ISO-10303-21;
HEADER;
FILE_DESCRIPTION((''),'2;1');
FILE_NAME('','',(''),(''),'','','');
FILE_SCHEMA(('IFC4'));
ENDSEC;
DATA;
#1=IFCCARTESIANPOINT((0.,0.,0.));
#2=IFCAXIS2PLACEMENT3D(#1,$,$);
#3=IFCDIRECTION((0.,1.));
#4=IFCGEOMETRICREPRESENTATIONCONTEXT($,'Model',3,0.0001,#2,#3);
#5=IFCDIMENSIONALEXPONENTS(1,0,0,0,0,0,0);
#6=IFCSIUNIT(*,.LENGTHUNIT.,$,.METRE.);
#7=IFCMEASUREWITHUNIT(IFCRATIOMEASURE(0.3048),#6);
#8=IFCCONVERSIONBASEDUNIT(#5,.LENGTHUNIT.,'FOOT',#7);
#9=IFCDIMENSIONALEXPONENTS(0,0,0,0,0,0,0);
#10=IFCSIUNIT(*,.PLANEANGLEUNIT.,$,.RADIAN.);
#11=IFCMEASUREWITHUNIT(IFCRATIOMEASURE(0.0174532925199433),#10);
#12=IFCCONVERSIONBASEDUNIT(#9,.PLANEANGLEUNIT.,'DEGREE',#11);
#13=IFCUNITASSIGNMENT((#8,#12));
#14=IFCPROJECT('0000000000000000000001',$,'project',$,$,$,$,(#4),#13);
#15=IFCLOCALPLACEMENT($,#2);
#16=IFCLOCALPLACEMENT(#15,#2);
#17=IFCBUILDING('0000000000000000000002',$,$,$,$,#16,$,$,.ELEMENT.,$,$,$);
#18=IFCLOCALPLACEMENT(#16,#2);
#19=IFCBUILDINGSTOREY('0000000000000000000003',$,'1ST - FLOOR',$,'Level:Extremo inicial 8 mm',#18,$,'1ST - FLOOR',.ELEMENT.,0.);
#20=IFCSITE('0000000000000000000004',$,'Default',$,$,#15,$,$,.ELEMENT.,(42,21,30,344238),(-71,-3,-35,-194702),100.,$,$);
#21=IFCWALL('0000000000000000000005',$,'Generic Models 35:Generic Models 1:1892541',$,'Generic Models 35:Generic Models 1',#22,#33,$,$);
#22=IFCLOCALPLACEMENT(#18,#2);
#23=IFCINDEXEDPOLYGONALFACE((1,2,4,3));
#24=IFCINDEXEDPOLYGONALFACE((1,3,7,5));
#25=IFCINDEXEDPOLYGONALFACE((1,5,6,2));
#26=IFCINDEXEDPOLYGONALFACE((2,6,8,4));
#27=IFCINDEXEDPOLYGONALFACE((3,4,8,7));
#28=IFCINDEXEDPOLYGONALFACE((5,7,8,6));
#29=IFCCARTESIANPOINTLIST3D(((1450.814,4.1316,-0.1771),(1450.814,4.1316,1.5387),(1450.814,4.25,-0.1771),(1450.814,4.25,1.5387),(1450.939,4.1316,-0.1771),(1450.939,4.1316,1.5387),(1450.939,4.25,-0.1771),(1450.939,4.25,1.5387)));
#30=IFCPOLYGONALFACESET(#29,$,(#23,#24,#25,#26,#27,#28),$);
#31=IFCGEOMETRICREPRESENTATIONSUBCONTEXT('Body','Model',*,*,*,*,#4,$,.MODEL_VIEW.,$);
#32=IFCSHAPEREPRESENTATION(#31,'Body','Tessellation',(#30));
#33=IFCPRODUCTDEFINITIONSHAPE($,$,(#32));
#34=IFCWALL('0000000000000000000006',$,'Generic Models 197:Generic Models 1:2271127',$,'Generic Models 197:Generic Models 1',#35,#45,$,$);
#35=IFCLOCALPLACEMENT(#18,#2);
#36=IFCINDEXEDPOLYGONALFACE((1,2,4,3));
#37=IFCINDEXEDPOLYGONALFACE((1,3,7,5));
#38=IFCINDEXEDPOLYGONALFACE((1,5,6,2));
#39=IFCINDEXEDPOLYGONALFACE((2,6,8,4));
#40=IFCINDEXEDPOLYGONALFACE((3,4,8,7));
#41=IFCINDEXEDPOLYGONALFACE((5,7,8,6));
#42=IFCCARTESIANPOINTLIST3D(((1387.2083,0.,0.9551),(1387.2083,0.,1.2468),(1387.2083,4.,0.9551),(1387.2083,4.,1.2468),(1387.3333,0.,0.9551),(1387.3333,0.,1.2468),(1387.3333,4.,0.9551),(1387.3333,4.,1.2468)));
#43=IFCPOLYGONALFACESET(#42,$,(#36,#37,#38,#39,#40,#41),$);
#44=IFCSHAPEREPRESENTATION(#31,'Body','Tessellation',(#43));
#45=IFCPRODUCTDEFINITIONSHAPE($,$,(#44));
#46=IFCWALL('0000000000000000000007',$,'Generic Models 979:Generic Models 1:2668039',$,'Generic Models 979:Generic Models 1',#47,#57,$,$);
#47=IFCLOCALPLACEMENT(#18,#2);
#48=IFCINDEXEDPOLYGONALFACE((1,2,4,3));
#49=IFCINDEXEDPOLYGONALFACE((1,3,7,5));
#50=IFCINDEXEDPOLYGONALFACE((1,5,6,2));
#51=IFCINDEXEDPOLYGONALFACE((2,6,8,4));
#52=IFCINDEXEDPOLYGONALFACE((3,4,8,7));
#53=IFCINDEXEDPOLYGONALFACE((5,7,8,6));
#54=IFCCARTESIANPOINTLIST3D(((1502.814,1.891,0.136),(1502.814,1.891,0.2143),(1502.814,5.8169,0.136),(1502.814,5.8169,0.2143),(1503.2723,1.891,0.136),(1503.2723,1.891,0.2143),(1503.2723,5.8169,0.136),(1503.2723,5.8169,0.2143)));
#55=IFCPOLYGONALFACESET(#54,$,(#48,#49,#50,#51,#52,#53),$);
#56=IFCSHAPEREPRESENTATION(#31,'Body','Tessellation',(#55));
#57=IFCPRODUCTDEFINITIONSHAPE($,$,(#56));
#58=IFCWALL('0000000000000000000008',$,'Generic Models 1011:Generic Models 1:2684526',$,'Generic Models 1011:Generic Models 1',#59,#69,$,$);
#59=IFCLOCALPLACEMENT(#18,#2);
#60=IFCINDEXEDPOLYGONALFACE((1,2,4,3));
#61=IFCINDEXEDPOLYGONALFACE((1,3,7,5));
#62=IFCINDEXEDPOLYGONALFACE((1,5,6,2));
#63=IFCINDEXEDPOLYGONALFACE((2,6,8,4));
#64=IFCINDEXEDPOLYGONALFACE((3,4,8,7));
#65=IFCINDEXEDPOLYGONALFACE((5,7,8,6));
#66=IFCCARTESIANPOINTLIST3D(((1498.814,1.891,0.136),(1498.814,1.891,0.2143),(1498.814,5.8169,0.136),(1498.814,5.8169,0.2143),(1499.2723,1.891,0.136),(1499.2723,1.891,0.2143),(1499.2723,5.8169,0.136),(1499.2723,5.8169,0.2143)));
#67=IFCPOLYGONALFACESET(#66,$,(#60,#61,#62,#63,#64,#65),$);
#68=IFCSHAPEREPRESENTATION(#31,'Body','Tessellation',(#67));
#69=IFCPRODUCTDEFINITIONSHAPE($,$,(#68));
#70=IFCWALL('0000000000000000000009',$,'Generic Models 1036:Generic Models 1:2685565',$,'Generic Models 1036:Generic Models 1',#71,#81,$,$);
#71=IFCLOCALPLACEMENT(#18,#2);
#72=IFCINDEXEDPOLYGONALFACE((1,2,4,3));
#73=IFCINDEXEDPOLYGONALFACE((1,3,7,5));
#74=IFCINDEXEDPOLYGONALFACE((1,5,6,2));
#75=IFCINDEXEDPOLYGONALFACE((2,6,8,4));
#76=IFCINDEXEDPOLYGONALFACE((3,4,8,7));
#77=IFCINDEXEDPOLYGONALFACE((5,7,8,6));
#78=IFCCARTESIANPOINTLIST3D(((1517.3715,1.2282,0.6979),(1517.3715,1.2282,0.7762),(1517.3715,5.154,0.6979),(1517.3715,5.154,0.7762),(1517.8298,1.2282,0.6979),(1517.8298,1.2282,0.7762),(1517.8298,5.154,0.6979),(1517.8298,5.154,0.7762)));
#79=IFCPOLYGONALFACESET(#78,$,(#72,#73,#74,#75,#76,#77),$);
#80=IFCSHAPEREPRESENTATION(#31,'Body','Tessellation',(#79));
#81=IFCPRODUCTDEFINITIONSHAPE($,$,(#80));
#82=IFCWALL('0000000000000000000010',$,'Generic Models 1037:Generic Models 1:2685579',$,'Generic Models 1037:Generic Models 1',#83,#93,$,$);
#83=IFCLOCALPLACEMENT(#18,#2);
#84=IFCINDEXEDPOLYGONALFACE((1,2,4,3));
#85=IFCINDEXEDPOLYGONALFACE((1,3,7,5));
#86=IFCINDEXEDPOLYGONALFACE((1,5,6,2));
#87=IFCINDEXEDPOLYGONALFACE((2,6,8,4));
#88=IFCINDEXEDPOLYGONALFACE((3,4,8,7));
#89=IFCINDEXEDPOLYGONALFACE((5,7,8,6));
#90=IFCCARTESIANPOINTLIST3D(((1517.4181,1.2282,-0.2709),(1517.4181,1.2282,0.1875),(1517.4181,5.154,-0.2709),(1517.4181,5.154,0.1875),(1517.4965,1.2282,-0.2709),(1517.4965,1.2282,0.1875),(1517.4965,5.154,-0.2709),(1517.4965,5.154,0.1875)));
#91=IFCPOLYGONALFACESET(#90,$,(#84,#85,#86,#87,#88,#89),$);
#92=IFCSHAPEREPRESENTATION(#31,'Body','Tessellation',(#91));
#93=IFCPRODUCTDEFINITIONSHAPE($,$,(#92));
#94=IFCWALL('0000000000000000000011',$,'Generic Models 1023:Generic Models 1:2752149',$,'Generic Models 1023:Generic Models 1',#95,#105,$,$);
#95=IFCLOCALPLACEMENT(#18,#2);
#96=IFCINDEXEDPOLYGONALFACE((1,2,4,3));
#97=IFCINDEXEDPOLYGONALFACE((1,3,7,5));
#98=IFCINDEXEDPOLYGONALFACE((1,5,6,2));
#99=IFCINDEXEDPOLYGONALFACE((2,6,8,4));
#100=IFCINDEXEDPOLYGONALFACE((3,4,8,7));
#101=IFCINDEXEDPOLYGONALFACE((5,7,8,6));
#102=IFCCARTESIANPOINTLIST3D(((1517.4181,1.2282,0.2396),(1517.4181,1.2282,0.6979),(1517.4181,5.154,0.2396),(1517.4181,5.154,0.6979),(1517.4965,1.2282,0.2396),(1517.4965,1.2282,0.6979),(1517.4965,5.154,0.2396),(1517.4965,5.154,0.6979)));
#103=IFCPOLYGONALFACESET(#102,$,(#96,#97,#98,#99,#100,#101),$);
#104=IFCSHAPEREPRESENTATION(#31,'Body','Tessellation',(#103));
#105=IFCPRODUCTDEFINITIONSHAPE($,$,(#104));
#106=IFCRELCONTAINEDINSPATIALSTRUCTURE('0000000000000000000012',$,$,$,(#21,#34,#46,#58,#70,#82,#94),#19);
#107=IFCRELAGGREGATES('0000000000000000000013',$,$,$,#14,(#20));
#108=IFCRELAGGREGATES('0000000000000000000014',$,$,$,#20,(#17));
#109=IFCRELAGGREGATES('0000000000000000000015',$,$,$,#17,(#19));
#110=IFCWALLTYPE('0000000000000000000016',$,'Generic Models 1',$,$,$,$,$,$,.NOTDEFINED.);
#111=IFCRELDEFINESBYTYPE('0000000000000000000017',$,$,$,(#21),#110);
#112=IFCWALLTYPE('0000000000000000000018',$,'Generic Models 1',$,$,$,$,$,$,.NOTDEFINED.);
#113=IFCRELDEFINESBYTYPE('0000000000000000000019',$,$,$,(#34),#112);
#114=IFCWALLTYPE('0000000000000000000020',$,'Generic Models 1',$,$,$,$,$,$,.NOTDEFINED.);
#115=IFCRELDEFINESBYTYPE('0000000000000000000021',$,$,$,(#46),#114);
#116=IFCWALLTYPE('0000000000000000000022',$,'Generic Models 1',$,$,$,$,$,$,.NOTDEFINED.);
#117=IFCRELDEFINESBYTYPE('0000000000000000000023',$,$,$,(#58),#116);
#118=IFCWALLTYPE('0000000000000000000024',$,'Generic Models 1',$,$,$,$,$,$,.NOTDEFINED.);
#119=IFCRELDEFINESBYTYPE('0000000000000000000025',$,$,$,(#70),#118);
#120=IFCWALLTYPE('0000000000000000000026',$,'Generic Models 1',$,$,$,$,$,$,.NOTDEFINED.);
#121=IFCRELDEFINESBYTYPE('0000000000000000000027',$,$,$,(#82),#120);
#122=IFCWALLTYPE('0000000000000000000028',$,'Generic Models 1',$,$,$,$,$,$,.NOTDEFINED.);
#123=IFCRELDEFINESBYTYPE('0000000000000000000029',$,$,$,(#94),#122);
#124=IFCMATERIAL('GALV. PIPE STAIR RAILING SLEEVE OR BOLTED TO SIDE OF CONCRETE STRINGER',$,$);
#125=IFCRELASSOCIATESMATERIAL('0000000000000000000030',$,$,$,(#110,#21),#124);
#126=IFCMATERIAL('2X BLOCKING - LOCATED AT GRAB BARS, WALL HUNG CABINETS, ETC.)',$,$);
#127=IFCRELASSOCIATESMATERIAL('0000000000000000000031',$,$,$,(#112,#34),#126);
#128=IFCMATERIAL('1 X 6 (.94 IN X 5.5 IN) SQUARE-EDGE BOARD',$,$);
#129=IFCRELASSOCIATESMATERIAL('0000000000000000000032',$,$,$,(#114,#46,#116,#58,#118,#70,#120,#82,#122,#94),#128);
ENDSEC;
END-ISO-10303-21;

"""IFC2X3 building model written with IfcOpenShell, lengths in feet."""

from ifc_helpers import new_model, entity, si_unit, converted_unit, direction, frame, frame_2d, origin, place, context, subcontext, project, spatial, rectangle, extrude, material, type_object, element, save


model = new_model("IFC2X3")

# Units and contexts
model_context = context("Model", 3, precision=0.0001, world=origin(), true_north=direction((0.0, 1.0)))
body_context = subcontext(model_context, "Body", "Model", "MODEL_VIEW")
ifc_project = project(units=[converted_unit("LENGTHUNIT", "FOOT", entity("IfcRatioMeasure", 0.3048), si_unit("LENGTHUNIT", "METRE"), dimensions=[1, 0, 0, 0, 0, 0, 0]), converted_unit("PLANEANGLEUNIT", "DEGREE", entity("IfcRatioMeasure", 0.0174532925199433), si_unit("PLANEANGLEUNIT", "RADIAN"), dimensions=[0, 0, 0, 0, 0, 0, 0])], contexts=[model_context])

# Site, building, storey
site_placement = place(None, origin())
site = spatial("IfcSite", under=ifc_project, at=site_placement, Name="Default", CompositionType="ELEMENT", RefLatitude=(42, 21, 30, 344238), RefLongitude=(-71, -3, -35, -194702), RefElevation=100.0)
building_placement = place(site_placement, origin())
building = spatial("IfcBuilding", under=site, at=building_placement, CompositionType="ELEMENT")
storey_placement = place(building_placement, origin())
storey = spatial("IfcBuildingStorey", under=building, at=storey_placement, Name="1ST - FLOOR", ObjectType="Level:Extremo inicial 8 mm", LongName="1ST - FLOOR", CompositionType="ELEMENT", Elevation=0.0)

# Walls
ifc_material_1 = material(Name="GALV. PIPE STAIR RAILING SLEEVE OR BOLTED TO SIDE OF CONCRETE STRINGER")
wall_type_1 = type_object("IfcWallType", Name="Generic Models 1", PredefinedType="NOTDEFINED", material=ifc_material_1)
wall_1_placement = place(storey_placement, frame((1450.814, 4.1316, -0.1771)))
element("IfcWall", 1, at=wall_1_placement, inside=storey, type_object=wall_type_1, material=ifc_material_1, Name="Generic Models 35:Generic Models 1:1892541", ObjectType="Generic Models 35:Generic Models 1", context=body_context, shape_type="SweptSolid", body=[
    extrude(rectangle(XDim=0.1184, YDim=0.125, at=frame_2d((0.0, 0.0), x_axis=(1.0, 0.0))), frame((0.0625, 0.0592, 0.0), z_axis=(0.0, 0.0, 1.0), x_axis=(0.0, 1.0, 0.0)), (0.0, 0.0, 1.0), 1.7158),
])
ifc_material_2 = material(Name="2X BLOCKING - LOCATED AT GRAB BARS, WALL HUNG CABINETS, ETC.)")
wall_type_2 = type_object("IfcWallType", Name="Generic Models 1", PredefinedType="NOTDEFINED", material=ifc_material_2)
wall_2_placement = place(storey_placement, frame((1387.2083, 0.0, 0.9551), z_axis=(0.0, 0.0, 1.0), x_axis=(0.0, 1.0, 0.0)))
element("IfcWall", 2, at=wall_2_placement, inside=storey, type_object=wall_type_2, material=ifc_material_2, Name="Generic Models 197:Generic Models 1:2271127", ObjectType="Generic Models 197:Generic Models 1", context=body_context, shape_type="SweptSolid", body=[
    extrude(rectangle(XDim=4.0, YDim=0.125, at=frame_2d((0.0, 0.0), x_axis=(1.0, 0.0))), frame((2.0, -0.0625, 0.0)), (0.0, 0.0, 1.0), 0.2917),
])
ifc_material_3 = material(Name="1 X 6 (.94 IN X 5.5 IN) SQUARE-EDGE BOARD")
wall_type_3 = type_object("IfcWallType", Name="Generic Models 1", PredefinedType="NOTDEFINED", material=ifc_material_3)
wall_3_placement = place(storey_placement, frame((1502.814, 1.891, 0.136), z_axis=(0.0, 0.0, 1.0), x_axis=(0.0, 1.0, 0.0)))
element("IfcWall", 3, at=wall_3_placement, inside=storey, type_object=wall_type_3, material=ifc_material_3, Name="Generic Models 979:Generic Models 1:2668039", ObjectType="Generic Models 979:Generic Models 1", context=body_context, shape_type="SweptSolid", body=[
    extrude(rectangle(XDim=3.9258, YDim=0.4583, at=frame_2d((0.0, 0.0), x_axis=(1.0, 0.0))), frame((1.9629, -0.2292, 0.0)), (0.0, 0.0, 1.0), 0.0783),
])
wall_type_4 = type_object("IfcWallType", Name="Generic Models 1", PredefinedType="NOTDEFINED", material=ifc_material_3)
wall_4_placement = place(storey_placement, frame((1498.814, 1.891, 0.136), z_axis=(0.0, 0.0, 1.0), x_axis=(0.0, 1.0, 0.0)))
element("IfcWall", 4, at=wall_4_placement, inside=storey, type_object=wall_type_4, material=ifc_material_3, Name="Generic Models 1011:Generic Models 1:2684526", ObjectType="Generic Models 1011:Generic Models 1", context=body_context, shape_type="SweptSolid", body=[
    extrude(rectangle(XDim=3.9258, YDim=0.4583, at=frame_2d((0.0, 0.0), x_axis=(1.0, 0.0))), frame((1.9629, -0.2292, 0.0)), (0.0, 0.0, 1.0), 0.0783),
])
wall_type_5 = type_object("IfcWallType", Name="Generic Models 1", PredefinedType="NOTDEFINED", material=ifc_material_3)
wall_5_placement = place(storey_placement, frame((1517.3715, 1.2282, 0.6979), z_axis=(0.0, 0.0, 1.0), x_axis=(0.0, 1.0, 0.0)))
element("IfcWall", 5, at=wall_5_placement, inside=storey, type_object=wall_type_5, material=ifc_material_3, Name="Generic Models 1036:Generic Models 1:2685565", ObjectType="Generic Models 1036:Generic Models 1", context=body_context, shape_type="SweptSolid", body=[
    extrude(rectangle(XDim=3.9258, YDim=0.4583, at=frame_2d((0.0, 0.0), x_axis=(1.0, 0.0))), frame((1.9629, -0.2292, 0.0)), (0.0, 0.0, 1.0), 0.0783),
])
wall_type_6 = type_object("IfcWallType", Name="Generic Models 1", PredefinedType="NOTDEFINED", material=ifc_material_3)
wall_6_placement = place(storey_placement, frame((1517.4181, 1.2282, -0.2709), z_axis=(0.0, 0.0, 1.0), x_axis=(0.0, 1.0, 0.0)))
element("IfcWall", 6, at=wall_6_placement, inside=storey, type_object=wall_type_6, material=ifc_material_3, Name="Generic Models 1037:Generic Models 1:2685579", ObjectType="Generic Models 1037:Generic Models 1", context=body_context, shape_type="SweptSolid", body=[
    extrude(rectangle(XDim=3.9258, YDim=0.0783, at=frame_2d((0.0, 0.0), x_axis=(1.0, 0.0))), frame((1.9629, -0.0392, 0.0)), (0.0, 0.0, 1.0), 0.4583),
])
wall_type_7 = type_object("IfcWallType", Name="Generic Models 1", PredefinedType="NOTDEFINED", material=ifc_material_3)
wall_7_placement = place(storey_placement, frame((1517.4181, 1.2282, 0.2396), z_axis=(0.0, 0.0, 1.0), x_axis=(0.0, 1.0, 0.0)))
element("IfcWall", 7, at=wall_7_placement, inside=storey, type_object=wall_type_7, material=ifc_material_3, Name="Generic Models 1023:Generic Models 1:2752149", ObjectType="Generic Models 1023:Generic Models 1", context=body_context, shape_type="SweptSolid", body=[
    extrude(rectangle(XDim=3.9258, YDim=0.0783, at=frame_2d((0.0, 0.0), x_axis=(1.0, 0.0))), frame((1.9629, -0.0392, 0.0)), (0.0, 0.0, 1.0), 0.4583),
])

save(model, "model.ifc")
